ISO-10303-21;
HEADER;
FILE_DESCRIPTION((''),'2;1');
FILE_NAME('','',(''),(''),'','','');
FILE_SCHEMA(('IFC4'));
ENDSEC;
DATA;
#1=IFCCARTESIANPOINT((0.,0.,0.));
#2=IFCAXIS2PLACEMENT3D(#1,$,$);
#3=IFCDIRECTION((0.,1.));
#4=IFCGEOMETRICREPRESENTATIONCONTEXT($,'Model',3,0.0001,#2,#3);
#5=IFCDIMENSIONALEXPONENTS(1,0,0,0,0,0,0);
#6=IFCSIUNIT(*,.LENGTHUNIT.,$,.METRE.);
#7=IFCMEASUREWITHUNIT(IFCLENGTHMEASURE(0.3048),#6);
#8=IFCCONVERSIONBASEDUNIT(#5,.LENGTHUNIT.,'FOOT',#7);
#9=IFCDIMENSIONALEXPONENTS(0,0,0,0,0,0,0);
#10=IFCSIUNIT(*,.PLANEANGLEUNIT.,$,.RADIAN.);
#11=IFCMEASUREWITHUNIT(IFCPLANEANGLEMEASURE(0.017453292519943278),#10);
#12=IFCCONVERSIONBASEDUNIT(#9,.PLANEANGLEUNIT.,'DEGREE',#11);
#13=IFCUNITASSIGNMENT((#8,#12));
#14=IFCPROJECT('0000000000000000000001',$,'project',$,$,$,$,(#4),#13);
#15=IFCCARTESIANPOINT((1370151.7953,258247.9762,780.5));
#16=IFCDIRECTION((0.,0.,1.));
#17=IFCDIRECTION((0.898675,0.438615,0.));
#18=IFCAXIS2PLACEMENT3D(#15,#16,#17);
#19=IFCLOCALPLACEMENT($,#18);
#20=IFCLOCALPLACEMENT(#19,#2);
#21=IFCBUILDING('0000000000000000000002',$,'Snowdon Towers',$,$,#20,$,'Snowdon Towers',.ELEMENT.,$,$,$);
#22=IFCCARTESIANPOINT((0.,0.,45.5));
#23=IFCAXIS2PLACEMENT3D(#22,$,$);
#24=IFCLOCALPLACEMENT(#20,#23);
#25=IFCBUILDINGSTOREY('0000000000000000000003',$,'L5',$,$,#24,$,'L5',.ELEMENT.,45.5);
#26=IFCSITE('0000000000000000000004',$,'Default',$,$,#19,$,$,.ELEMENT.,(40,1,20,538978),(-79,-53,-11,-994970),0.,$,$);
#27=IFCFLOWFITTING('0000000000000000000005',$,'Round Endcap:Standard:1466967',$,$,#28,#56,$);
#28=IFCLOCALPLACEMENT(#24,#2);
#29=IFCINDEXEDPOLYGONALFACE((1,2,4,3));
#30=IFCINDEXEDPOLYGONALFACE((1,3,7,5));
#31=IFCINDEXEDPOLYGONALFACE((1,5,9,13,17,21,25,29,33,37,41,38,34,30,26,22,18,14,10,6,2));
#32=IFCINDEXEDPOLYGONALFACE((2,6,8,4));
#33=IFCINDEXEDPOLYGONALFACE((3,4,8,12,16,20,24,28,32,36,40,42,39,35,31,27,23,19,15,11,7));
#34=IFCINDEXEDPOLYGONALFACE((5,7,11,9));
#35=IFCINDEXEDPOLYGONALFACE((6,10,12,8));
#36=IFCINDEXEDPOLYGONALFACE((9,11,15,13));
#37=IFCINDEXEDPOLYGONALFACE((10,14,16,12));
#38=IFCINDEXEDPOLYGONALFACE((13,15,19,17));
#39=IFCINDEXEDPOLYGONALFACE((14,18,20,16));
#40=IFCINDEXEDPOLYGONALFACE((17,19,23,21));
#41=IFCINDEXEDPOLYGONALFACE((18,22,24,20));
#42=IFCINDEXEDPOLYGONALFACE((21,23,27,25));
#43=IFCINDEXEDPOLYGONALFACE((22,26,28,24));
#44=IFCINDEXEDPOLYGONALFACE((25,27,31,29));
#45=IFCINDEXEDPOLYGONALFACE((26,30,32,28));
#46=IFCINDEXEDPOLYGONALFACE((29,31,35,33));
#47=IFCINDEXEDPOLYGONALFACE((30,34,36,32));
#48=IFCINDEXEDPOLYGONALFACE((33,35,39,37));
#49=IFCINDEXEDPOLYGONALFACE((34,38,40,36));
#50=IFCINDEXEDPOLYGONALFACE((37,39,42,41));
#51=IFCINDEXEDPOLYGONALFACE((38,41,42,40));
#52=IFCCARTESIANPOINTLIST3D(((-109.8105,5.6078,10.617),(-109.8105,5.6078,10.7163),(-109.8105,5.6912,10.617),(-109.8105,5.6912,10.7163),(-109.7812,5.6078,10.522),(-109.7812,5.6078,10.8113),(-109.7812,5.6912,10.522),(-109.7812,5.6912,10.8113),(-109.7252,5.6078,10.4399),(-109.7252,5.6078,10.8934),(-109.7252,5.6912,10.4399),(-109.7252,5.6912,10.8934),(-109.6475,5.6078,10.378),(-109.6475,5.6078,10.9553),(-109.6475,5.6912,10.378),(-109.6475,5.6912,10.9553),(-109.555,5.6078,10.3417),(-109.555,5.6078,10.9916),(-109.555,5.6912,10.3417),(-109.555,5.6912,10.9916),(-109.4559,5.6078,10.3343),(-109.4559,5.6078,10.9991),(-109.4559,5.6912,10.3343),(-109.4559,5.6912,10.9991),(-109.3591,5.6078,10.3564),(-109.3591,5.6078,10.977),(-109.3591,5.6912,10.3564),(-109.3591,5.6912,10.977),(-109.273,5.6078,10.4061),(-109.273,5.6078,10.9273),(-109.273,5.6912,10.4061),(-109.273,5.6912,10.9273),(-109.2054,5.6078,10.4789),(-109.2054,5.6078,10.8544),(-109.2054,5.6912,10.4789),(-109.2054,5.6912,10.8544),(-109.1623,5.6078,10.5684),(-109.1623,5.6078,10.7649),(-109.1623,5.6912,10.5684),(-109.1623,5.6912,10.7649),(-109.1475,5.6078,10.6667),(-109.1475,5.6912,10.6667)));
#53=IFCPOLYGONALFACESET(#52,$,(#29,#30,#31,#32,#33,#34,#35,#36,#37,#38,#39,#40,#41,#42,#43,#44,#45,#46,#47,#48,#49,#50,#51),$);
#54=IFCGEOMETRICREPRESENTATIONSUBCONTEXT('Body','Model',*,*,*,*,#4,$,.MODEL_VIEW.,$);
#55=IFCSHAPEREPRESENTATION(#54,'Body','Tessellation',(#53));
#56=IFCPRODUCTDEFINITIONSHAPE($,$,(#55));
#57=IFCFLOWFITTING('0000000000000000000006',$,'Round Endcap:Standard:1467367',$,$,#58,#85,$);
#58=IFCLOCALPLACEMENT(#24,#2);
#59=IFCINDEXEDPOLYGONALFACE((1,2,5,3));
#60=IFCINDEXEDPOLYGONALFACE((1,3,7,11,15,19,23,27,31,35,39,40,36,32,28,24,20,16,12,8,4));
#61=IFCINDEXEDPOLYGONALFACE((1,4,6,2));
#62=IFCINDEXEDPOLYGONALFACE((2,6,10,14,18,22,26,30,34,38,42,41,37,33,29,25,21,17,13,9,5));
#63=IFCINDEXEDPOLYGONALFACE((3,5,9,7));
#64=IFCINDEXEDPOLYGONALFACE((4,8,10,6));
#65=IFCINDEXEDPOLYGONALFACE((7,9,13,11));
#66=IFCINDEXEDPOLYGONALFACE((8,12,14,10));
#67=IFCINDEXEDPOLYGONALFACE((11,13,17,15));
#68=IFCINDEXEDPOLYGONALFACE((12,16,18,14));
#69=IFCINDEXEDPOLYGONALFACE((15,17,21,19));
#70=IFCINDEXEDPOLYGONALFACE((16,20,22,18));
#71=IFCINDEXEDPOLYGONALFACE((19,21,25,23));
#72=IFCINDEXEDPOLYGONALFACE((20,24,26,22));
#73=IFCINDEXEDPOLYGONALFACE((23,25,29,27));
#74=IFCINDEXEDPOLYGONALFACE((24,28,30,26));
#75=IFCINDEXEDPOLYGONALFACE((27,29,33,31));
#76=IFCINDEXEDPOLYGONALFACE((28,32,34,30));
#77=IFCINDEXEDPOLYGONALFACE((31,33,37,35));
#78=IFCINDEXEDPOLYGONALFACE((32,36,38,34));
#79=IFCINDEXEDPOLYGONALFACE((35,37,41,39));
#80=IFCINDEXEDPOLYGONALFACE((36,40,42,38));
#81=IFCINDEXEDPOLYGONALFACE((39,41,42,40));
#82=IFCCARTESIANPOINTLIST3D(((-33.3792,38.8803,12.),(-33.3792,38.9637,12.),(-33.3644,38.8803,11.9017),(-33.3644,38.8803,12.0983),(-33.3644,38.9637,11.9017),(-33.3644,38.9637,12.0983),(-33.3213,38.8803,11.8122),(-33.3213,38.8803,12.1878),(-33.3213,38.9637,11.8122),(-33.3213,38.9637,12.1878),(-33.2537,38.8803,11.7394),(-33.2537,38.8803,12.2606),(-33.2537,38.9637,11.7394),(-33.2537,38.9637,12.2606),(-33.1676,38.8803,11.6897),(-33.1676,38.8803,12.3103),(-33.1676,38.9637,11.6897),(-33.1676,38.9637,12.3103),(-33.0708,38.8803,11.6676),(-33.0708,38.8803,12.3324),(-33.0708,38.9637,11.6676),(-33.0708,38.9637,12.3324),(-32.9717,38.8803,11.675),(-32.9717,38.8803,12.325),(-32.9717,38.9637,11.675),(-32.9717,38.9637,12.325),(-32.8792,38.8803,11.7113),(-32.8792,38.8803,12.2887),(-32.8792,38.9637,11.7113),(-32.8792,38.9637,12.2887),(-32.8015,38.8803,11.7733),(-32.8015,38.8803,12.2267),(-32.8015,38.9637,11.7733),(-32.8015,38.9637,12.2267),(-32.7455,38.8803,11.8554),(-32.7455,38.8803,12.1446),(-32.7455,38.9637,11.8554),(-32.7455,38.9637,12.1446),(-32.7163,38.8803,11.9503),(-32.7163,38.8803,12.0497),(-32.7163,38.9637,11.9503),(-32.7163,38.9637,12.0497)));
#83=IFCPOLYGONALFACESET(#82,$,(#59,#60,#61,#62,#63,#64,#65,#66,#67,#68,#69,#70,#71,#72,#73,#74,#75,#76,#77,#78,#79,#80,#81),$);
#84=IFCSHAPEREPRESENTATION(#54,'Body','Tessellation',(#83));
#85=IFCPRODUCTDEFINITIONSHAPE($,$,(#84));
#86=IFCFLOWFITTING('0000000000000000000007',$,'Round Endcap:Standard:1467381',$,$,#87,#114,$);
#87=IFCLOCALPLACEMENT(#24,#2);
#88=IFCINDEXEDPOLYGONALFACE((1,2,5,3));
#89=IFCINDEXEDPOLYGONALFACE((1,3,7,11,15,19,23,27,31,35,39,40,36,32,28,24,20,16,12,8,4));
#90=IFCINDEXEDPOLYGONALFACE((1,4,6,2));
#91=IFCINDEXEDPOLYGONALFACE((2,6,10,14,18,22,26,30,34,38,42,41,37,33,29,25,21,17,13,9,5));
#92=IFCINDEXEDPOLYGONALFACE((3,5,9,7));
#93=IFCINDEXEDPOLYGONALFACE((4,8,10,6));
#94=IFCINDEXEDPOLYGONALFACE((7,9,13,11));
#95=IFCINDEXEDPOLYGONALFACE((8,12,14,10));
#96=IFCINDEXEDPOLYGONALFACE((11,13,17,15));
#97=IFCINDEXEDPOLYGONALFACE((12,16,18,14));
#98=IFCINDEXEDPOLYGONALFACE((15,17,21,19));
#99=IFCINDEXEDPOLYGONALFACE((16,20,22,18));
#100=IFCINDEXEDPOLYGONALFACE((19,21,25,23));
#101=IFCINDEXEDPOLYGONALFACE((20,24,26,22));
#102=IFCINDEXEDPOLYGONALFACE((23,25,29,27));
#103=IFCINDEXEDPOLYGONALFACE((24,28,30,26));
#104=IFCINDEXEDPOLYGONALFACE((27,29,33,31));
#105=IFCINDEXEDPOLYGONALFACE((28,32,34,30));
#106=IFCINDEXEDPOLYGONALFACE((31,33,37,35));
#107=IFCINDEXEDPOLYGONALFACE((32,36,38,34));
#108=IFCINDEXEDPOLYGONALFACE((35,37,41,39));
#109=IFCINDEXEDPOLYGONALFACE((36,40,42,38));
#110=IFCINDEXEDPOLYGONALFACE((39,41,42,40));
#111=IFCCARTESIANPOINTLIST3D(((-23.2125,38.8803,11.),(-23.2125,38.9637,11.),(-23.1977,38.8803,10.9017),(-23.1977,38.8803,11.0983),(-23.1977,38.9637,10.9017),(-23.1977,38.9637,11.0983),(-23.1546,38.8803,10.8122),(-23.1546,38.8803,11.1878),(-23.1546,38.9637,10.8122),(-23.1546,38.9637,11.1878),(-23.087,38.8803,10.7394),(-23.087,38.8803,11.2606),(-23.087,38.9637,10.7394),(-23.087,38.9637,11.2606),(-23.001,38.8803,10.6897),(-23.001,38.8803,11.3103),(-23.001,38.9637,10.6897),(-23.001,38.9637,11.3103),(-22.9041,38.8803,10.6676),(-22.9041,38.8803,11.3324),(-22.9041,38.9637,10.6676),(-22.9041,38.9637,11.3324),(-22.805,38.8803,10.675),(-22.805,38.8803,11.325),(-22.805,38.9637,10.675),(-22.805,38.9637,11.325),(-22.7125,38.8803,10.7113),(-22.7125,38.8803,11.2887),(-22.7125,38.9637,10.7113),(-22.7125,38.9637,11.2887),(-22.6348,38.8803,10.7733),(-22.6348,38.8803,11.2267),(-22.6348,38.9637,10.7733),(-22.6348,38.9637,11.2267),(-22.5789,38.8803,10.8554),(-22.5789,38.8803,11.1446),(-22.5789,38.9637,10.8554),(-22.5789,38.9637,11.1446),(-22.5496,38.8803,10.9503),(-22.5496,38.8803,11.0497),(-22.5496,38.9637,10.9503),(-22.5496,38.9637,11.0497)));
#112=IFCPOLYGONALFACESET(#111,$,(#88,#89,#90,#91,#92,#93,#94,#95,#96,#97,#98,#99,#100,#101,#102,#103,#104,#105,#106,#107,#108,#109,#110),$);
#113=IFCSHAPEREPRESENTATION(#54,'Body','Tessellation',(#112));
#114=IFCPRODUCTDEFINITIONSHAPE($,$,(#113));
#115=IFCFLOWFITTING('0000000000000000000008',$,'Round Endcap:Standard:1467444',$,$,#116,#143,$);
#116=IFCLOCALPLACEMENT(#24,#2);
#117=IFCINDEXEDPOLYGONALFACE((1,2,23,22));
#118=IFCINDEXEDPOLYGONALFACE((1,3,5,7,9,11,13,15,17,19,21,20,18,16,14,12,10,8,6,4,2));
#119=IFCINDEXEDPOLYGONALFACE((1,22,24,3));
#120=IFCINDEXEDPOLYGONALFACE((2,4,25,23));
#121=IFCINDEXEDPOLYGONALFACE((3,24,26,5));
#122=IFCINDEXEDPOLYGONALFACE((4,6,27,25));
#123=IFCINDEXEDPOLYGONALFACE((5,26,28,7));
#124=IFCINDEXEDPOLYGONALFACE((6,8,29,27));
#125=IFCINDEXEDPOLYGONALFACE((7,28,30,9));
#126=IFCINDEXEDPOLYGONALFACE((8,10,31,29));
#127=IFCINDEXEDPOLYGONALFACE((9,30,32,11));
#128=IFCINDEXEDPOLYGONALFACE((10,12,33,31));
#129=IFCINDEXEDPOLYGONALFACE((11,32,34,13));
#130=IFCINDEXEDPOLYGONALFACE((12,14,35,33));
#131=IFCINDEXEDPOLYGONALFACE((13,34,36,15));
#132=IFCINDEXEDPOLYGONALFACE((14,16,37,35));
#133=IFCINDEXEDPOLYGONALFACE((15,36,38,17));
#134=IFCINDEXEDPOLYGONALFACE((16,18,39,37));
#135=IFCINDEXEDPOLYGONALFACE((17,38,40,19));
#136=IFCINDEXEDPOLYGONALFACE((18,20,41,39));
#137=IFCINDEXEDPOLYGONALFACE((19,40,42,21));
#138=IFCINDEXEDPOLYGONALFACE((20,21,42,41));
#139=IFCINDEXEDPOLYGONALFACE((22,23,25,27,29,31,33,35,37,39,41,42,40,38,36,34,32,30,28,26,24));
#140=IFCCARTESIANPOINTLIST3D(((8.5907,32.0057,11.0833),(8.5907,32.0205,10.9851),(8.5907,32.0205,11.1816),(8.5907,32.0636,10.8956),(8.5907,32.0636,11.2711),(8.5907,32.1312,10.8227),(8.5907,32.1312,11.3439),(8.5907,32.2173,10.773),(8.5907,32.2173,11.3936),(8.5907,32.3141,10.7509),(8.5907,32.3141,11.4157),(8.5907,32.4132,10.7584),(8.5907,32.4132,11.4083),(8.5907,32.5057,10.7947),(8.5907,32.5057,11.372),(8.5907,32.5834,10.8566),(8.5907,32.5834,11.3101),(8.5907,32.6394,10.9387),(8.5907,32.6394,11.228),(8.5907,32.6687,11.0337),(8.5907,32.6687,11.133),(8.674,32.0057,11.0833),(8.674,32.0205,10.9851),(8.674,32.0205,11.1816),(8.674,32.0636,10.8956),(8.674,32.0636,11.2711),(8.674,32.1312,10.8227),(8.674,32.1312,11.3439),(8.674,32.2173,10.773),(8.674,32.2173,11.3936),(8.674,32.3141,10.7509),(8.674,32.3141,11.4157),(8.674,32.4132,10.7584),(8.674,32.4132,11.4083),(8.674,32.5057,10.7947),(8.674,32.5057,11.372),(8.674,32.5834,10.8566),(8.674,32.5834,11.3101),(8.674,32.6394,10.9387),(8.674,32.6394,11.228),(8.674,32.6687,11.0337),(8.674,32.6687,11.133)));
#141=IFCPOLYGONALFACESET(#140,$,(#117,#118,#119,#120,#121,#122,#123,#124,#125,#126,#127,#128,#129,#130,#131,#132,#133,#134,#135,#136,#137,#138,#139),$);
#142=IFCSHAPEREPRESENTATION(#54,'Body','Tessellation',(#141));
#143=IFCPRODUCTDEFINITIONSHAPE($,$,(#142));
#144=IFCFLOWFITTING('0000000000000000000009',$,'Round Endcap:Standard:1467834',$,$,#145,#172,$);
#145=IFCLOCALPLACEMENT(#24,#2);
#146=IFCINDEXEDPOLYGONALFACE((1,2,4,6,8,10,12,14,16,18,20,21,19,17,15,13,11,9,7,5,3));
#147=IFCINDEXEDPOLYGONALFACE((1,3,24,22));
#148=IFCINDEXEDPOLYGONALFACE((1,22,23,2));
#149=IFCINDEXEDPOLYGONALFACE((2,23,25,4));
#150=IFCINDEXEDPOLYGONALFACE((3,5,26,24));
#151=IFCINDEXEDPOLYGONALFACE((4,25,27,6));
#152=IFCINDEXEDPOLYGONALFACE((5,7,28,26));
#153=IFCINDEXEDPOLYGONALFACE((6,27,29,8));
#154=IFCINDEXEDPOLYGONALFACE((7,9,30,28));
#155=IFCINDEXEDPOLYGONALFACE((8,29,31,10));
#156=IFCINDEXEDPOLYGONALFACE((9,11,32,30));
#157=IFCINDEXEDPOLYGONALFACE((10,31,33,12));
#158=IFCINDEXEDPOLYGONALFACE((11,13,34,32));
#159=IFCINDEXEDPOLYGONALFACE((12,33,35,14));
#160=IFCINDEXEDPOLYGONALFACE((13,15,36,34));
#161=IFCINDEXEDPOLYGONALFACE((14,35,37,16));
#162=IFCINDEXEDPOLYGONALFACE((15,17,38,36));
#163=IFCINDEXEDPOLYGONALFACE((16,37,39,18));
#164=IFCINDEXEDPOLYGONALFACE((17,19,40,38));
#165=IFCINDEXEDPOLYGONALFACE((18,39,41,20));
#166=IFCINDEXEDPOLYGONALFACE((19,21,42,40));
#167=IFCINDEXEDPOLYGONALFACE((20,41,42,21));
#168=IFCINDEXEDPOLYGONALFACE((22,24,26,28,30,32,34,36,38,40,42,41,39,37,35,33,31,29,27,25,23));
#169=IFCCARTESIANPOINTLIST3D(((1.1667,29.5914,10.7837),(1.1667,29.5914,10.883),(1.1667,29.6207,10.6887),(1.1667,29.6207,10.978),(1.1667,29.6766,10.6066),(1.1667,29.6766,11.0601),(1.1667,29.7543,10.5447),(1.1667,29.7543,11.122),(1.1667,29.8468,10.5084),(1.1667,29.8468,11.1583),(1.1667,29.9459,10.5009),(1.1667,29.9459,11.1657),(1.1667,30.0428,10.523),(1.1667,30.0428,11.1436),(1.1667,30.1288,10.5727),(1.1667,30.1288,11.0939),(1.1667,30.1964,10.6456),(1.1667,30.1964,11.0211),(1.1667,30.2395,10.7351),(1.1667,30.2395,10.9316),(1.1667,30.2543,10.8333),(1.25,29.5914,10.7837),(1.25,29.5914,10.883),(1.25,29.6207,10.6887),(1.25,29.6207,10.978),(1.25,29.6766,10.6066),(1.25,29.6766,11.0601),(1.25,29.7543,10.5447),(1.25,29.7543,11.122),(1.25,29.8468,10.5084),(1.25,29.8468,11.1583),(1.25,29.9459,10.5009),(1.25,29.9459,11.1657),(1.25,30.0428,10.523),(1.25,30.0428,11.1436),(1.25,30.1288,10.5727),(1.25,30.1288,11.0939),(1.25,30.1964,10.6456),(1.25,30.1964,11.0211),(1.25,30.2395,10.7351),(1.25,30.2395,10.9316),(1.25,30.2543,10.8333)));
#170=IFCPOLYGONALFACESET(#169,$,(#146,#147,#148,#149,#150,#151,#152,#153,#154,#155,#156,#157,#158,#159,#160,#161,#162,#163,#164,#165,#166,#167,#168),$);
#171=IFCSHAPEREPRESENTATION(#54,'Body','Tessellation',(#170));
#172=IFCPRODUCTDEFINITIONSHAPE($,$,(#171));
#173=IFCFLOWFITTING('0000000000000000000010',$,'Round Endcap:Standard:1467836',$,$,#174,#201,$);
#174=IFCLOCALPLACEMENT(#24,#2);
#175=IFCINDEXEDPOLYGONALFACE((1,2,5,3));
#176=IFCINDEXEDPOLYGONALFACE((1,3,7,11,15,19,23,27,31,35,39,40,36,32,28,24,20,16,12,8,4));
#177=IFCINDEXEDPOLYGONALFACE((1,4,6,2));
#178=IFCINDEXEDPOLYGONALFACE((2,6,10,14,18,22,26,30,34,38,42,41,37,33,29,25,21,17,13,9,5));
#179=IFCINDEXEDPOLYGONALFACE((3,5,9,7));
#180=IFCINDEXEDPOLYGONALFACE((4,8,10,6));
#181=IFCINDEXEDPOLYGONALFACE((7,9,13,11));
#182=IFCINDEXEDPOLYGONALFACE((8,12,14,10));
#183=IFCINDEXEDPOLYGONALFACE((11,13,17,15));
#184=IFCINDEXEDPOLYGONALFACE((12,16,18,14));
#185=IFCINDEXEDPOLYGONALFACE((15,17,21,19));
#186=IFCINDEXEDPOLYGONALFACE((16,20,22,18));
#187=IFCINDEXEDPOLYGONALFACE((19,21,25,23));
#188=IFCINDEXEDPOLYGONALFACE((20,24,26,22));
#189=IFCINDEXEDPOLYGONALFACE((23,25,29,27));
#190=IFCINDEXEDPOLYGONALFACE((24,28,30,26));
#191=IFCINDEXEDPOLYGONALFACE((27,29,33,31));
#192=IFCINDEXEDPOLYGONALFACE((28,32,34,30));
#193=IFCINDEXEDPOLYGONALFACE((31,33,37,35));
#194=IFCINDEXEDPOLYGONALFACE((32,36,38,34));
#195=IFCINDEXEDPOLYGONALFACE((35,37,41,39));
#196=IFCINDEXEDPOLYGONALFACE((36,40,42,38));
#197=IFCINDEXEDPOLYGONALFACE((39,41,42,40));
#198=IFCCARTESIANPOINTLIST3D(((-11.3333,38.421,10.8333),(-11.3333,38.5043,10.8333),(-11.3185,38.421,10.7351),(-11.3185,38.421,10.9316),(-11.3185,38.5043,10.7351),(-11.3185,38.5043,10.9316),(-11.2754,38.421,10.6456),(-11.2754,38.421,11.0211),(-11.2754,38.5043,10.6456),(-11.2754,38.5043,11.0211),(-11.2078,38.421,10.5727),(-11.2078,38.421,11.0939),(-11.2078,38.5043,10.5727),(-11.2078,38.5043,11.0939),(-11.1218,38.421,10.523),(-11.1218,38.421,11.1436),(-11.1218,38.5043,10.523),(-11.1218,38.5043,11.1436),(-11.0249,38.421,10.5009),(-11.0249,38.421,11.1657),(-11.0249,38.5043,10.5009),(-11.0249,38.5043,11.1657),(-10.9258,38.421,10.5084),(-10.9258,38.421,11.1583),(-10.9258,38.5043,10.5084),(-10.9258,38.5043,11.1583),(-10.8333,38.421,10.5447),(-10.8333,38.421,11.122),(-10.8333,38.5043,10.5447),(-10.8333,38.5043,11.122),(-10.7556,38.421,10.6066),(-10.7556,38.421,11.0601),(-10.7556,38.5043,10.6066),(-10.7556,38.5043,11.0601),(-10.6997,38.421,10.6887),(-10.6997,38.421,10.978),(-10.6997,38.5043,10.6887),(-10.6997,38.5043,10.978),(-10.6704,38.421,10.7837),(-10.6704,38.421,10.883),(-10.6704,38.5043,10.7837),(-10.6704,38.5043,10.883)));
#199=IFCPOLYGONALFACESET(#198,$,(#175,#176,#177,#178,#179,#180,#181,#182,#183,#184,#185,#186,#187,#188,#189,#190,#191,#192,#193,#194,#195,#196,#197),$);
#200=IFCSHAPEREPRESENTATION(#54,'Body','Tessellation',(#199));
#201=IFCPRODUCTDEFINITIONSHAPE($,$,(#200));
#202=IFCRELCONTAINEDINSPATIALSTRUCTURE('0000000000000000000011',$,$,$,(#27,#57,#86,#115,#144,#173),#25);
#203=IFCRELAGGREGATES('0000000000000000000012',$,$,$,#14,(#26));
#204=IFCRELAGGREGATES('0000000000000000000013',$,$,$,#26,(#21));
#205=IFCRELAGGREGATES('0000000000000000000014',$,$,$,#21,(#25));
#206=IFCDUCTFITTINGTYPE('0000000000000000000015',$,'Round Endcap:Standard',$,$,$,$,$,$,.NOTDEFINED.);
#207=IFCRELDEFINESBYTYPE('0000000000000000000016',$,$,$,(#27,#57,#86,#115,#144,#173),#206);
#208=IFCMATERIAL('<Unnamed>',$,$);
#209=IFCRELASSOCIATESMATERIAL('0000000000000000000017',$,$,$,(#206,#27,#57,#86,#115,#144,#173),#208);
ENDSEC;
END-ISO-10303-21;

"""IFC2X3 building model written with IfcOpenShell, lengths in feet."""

from ifc_helpers import new_model, entity, si_unit, converted_unit, direction, frame, frame_2d, origin, place, context, subcontext, project, spatial, circle, extrude, source, transform, mapped, material, type_object, type_shapes, element, save


model = new_model("IFC2X3")

# Units and contexts
model_context = context("Model", 3, precision=0.0001, world=origin(), true_north=direction((0.0, 1.0)))
body_context = subcontext(model_context, "Body", "Model", "MODEL_VIEW")
ifc_project = project(units=[converted_unit("LENGTHUNIT", "FOOT", entity("IfcLengthMeasure", 0.3048), si_unit("LENGTHUNIT", "METRE"), dimensions=[1, 0, 0, 0, 0, 0, 0]), converted_unit("PLANEANGLEUNIT", "DEGREE", entity("IfcPlaneAngleMeasure", 0.017453292519943278), si_unit("PLANEANGLEUNIT", "RADIAN"), dimensions=[0, 0, 0, 0, 0, 0, 0])], contexts=[model_context])

# Site, building, storey
site_placement = place(None, frame((1370151.7953, 258247.9762, 780.5), z_axis=(0.0, 0.0, 1.0), x_axis=(0.898675, 0.438615, 0.0)))
site = spatial("IfcSite", under=ifc_project, at=site_placement, Name="Default", CompositionType="ELEMENT", RefLatitude=(40, 1, 20, 538978), RefLongitude=(-79, -53, -11, -994970), RefElevation=0.0)
building_placement = place(site_placement, origin())
building = spatial("IfcBuilding", under=site, at=building_placement, Name="Snowdon Towers", LongName="Snowdon Towers", CompositionType="ELEMENT")
storey_placement = place(building_placement, frame((0.0, 0.0, 45.5)))
storey = spatial("IfcBuildingStorey", under=building, at=storey_placement, Name="L5", LongName="L5", CompositionType="ELEMENT", Elevation=45.5)

# Flow fittings
ifc_material = material(Name="<Unnamed>")
duct_fitting_type = type_object("IfcDuctFittingType", Name="Round Endcap:Standard", PredefinedType="NOTDEFINED", material=ifc_material)
shared_shape_1 = source(origin(), body_context, "Body", "SweptSolid", [
    extrude(circle(Radius=0.3333, at=frame_2d((0.0, 0.0), x_axis=(1.0, 0.0))), frame((0.0, 0.0, 0.0), z_axis=(1.0, 0.0, 0.0), x_axis=(0.0, 1.0, 0.0)), (0.0, 0.0, 1.0), 0.0833),
])
type_shapes(duct_fitting_type, [shared_shape_1])
for number, where, z_axis, x_axis, name in (
    (1, (-109.4808, 5.6912, 10.6667), (0.0, 0.0, 1.0), (0.0, -1.0, 0.0), "Round Endcap:Standard:1466967"),
    (2, (-33.0459, 38.8803, 12.0), (0.0, 0.0, 1.0), (0.0, 1.0, 0.0), "Round Endcap:Standard:1467367"),
    (3, (-22.8792, 38.8803, 11.0), (0.0, 0.0, 1.0), (0.0, 1.0, 0.0), "Round Endcap:Standard:1467381"),
    (4, (8.674, 32.339, 11.0833), (0.0, 0.0, 1.0), (-1.0, 0.0, 0.0), "Round Endcap:Standard:1467444"),
):
    element("IfcFlowFitting", number, at=place(storey_placement, frame(where, z_axis=z_axis, x_axis=x_axis)), inside=storey, type_object=duct_fitting_type, material=ifc_material, Name=name, context=body_context, shape_type="MappedRepresentation", body=[
        mapped(shared_shape_1, transform((0.0, 0.0, 0.0), scale=1.0)),
    ])
flow_fitting_1_placement = place(storey_placement, frame((1.1667, 29.921, 10.8333)))
element("IfcFlowFitting", 5, at=flow_fitting_1_placement, inside=storey, type_object=duct_fitting_type, material=ifc_material, Name="Round Endcap:Standard:1467834", context=body_context, shape_type="MappedRepresentation", body=[
    mapped(shared_shape_1, transform((0.0, 0.0, 0.0), scale=1.0)),
])
flow_fitting_2_placement = place(storey_placement, frame((-11.0, 38.421, 10.8333), z_axis=(0.0, 0.0, 1.0), x_axis=(0.0, 1.0, 0.0)))
element("IfcFlowFitting", 6, at=flow_fitting_2_placement, inside=storey, type_object=duct_fitting_type, material=ifc_material, Name="Round Endcap:Standard:1467836", context=body_context, shape_type="MappedRepresentation", body=[
    mapped(shared_shape_1, transform((0.0, 0.0, 0.0), scale=1.0)),
])

save(model, "model.ifc")
